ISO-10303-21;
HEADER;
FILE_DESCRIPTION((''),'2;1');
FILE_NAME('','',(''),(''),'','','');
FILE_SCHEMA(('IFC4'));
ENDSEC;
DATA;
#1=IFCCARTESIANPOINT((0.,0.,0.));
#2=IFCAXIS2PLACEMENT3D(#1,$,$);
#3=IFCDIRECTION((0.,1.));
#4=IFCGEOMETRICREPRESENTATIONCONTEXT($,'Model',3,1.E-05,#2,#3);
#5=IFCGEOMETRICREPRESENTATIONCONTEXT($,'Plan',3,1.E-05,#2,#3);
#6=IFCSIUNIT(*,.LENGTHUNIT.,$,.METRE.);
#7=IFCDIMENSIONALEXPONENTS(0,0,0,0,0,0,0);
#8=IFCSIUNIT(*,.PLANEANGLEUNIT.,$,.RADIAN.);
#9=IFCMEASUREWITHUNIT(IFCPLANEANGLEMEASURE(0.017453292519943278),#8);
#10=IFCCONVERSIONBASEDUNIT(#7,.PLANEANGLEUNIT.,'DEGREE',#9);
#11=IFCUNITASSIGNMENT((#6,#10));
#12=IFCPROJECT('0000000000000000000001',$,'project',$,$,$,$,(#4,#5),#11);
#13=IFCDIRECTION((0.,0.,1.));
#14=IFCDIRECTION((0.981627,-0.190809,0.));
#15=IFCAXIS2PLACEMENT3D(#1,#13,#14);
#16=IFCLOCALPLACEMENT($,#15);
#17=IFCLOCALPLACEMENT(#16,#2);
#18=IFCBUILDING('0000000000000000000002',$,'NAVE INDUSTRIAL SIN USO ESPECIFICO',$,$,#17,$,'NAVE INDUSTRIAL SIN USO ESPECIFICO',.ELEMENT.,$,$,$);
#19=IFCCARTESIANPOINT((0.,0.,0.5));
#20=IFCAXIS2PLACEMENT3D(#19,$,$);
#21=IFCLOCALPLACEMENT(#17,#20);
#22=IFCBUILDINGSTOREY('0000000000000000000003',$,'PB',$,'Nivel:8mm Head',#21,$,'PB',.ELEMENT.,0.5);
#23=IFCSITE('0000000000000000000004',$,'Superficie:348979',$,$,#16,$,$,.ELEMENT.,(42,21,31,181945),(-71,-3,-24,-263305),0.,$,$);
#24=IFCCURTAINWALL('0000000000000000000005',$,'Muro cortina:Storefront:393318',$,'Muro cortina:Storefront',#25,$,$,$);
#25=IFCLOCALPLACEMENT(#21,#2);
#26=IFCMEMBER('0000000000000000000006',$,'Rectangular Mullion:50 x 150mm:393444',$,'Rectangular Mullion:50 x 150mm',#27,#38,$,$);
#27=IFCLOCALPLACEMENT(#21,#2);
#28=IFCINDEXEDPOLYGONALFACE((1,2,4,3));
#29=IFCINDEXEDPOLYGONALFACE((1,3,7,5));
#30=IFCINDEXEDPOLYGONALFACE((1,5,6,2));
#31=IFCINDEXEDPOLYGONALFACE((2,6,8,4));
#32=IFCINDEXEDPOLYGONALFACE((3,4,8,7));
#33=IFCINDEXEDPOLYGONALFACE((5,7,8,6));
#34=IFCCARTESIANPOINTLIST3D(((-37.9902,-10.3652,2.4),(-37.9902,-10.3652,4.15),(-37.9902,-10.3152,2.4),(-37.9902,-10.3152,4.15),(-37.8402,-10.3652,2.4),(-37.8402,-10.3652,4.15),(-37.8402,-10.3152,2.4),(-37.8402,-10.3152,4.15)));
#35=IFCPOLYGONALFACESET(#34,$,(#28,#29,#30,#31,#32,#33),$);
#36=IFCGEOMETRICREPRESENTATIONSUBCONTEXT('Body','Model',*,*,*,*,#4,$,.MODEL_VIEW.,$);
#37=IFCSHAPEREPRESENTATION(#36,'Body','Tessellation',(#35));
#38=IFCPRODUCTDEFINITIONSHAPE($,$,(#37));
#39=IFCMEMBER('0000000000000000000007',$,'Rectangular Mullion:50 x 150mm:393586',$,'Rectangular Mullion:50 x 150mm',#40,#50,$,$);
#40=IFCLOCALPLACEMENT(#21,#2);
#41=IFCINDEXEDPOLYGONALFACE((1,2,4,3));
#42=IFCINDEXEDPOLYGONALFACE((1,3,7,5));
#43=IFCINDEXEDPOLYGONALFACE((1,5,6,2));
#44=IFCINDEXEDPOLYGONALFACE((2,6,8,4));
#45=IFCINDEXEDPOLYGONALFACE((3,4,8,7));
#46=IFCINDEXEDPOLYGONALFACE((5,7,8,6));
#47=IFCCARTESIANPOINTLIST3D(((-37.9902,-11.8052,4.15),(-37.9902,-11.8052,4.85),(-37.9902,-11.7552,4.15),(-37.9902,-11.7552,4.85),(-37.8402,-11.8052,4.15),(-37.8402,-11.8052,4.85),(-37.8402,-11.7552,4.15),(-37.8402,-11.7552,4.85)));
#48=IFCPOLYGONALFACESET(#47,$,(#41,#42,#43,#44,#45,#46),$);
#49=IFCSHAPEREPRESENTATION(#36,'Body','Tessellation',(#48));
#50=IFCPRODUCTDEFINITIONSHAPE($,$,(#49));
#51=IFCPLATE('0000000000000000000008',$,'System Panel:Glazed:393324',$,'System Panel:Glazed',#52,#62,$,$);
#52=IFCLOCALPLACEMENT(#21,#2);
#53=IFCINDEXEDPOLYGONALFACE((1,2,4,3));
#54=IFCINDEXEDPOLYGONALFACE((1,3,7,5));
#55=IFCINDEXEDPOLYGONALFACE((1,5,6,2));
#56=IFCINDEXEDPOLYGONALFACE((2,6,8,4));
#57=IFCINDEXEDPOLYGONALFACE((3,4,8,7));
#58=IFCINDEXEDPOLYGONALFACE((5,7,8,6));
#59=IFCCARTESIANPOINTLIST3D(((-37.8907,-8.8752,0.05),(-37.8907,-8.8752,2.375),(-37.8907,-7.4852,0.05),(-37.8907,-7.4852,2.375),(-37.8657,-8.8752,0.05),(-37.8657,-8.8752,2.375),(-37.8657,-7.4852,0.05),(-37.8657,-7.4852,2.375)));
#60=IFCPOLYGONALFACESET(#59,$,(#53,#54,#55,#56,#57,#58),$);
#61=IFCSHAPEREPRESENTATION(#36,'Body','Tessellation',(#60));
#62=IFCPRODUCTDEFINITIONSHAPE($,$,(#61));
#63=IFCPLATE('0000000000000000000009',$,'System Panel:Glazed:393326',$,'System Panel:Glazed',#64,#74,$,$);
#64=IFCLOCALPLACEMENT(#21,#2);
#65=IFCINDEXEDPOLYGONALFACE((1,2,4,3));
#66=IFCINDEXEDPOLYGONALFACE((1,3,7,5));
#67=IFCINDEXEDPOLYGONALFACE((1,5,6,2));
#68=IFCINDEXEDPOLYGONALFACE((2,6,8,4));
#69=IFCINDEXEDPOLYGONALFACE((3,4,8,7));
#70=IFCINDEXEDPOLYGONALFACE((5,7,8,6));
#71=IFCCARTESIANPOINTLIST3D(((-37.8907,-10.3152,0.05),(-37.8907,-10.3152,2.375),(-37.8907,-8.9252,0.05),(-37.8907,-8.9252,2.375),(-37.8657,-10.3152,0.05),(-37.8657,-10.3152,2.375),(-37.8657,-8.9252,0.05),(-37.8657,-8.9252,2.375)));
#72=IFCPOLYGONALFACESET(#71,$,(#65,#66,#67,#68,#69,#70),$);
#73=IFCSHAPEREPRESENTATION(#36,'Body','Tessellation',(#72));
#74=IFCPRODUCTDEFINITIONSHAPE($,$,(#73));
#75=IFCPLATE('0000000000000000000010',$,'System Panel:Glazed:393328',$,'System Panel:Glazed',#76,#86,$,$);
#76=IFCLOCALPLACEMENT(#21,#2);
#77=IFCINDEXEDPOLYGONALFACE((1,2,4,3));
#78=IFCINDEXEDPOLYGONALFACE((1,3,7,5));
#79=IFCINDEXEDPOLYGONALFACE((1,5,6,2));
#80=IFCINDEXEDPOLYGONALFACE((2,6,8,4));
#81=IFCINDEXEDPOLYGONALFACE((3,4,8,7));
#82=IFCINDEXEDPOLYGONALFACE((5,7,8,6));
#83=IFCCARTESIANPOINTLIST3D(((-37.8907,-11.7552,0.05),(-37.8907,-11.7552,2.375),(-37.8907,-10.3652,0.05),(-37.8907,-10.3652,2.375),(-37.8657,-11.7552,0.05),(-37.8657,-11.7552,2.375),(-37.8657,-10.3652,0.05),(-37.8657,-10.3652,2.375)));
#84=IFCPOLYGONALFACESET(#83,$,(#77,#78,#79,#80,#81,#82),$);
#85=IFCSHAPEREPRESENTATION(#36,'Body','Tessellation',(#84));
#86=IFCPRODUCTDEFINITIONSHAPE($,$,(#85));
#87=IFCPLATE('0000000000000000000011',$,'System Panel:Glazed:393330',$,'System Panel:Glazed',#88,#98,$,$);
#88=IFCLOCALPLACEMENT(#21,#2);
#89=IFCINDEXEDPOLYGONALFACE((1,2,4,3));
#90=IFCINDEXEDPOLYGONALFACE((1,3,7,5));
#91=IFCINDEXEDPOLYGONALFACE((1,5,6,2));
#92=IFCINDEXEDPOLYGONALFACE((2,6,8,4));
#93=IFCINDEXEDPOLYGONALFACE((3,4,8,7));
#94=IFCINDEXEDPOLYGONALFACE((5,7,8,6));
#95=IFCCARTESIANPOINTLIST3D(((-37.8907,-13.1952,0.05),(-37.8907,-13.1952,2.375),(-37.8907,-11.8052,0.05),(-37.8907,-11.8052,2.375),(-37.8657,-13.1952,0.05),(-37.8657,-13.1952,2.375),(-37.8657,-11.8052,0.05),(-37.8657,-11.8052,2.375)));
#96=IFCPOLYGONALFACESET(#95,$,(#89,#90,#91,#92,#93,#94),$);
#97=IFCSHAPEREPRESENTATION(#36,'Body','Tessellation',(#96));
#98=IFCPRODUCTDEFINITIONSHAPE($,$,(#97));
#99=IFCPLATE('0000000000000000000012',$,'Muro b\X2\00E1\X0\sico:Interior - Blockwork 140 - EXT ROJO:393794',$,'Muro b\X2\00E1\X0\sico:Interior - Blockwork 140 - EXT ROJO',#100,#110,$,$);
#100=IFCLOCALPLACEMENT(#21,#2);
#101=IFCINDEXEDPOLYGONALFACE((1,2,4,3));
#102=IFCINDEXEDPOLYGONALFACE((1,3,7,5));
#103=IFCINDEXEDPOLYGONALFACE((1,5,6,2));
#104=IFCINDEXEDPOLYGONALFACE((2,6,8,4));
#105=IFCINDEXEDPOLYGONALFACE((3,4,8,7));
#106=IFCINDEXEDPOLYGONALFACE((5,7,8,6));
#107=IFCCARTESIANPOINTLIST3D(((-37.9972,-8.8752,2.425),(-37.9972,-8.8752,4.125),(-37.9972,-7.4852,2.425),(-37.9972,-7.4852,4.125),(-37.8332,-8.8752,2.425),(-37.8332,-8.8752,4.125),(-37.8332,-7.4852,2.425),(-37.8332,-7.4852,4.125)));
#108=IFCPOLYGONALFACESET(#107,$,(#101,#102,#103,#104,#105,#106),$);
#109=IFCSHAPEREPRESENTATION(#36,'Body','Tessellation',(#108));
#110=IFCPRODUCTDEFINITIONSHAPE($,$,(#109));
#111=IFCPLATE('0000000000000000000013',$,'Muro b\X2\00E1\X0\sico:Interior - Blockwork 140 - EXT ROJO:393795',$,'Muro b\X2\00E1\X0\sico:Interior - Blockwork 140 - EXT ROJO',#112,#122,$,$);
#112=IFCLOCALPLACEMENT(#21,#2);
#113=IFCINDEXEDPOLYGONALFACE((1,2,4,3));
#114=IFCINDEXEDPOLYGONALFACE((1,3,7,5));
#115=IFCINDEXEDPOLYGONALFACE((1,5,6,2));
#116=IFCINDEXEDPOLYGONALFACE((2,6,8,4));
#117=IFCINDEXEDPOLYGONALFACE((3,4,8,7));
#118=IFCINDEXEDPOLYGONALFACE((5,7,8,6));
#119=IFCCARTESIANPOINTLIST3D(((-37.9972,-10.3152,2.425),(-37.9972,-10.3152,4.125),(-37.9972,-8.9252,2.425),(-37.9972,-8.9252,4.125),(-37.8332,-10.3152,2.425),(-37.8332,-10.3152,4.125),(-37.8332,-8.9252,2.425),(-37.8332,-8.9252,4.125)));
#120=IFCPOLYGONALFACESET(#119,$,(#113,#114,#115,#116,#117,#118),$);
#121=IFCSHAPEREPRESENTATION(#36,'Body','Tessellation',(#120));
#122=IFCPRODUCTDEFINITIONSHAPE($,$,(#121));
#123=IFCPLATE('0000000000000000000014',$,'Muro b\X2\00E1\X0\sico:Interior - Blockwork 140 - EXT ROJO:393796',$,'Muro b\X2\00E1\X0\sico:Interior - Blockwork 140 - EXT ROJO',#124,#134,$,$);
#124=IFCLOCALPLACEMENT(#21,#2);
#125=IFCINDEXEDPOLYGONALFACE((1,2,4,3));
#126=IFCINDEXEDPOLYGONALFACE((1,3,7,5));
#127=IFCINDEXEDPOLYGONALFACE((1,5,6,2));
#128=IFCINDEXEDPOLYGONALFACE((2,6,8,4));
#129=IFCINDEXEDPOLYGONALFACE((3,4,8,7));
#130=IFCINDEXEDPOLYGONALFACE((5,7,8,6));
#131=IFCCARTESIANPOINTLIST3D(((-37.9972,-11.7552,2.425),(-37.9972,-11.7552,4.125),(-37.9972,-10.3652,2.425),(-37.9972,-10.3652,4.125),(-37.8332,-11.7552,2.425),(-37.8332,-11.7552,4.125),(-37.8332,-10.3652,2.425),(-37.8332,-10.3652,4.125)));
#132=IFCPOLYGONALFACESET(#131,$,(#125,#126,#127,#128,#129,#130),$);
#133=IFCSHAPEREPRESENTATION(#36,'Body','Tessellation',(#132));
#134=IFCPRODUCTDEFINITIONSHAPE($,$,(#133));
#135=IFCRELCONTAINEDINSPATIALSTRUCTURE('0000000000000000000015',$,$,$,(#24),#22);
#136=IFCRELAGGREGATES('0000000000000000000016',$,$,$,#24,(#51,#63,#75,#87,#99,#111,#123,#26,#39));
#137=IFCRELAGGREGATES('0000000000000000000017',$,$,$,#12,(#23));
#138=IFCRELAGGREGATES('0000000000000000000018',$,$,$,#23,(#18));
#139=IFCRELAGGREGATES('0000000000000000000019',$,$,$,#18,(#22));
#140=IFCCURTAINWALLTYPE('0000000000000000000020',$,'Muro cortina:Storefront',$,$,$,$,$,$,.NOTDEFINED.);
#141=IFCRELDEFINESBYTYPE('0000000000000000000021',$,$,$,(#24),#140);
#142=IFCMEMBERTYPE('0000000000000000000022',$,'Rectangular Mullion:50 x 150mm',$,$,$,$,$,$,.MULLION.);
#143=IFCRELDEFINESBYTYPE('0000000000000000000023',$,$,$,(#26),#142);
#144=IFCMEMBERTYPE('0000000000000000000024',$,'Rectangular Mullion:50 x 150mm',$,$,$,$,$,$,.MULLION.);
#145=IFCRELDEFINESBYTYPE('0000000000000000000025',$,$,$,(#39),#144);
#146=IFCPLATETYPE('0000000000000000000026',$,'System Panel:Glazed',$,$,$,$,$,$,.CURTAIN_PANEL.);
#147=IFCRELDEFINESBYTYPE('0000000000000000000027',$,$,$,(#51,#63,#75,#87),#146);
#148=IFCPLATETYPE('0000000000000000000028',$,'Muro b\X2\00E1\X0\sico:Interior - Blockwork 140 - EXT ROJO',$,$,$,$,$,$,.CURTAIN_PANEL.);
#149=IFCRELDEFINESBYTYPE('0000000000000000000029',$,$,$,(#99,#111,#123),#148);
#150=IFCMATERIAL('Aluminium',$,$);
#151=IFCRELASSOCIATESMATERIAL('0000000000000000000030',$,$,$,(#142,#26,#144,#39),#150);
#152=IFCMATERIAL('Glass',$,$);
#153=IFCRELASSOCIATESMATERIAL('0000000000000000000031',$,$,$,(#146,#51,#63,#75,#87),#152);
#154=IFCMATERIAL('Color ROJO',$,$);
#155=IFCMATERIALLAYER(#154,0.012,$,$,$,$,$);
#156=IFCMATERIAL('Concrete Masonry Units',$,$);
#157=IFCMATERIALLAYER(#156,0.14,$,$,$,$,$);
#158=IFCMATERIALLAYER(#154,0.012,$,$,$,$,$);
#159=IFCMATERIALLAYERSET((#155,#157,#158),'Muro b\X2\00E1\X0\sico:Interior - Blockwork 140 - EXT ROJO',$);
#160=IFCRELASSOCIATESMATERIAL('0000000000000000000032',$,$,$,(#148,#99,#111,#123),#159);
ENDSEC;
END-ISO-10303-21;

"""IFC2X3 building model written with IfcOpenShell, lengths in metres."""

from ifc_helpers import new_model, entity, si_unit, converted_unit, direction, frame, frame_2d, origin, origin_2d_with_axis, place, context, subcontext, project, spatial, rectangle, extrude, source, transform, mapped, material, layer, layer_set, layer_usage, type_object, type_shapes, element, aggregate, save


model = new_model("IFC2X3")

# Units and contexts
model_context = context("Model", 3, precision=1e-05, world=origin(), true_north=direction((0.0, 1.0)))
plan_context = context("Plan", 3, precision=1e-05, world=origin(), true_north=direction((0.0, 1.0)))
body_context = subcontext(model_context, "Body", "Model", "MODEL_VIEW")
ifc_project = project(units=[si_unit("LENGTHUNIT", "METRE"), converted_unit("PLANEANGLEUNIT", "DEGREE", entity("IfcPlaneAngleMeasure", 0.017453292519943278), si_unit("PLANEANGLEUNIT", "RADIAN"), dimensions=[0, 0, 0, 0, 0, 0, 0])], contexts=[model_context, plan_context])

# Site, building, storey
site_placement = place(None, frame((0.0, 0.0, 0.0), z_axis=(0.0, 0.0, 1.0), x_axis=(0.981627, -0.190809, 0.0)))
site = spatial("IfcSite", under=ifc_project, at=site_placement, Name="Superficie:348979", CompositionType="ELEMENT", RefLatitude=(42, 21, 31, 181945), RefLongitude=(-71, -3, -24, -263305), RefElevation=0.0)
building_placement = place(site_placement, origin())
building = spatial("IfcBuilding", under=site, at=building_placement, Name="NAVE INDUSTRIAL SIN USO ESPECIFICO", LongName="NAVE INDUSTRIAL SIN USO ESPECIFICO", CompositionType="ELEMENT")
storey_placement = place(building_placement, frame((0.0, 0.0, 0.5)))
storey = spatial("IfcBuildingStorey", under=building, at=storey_placement, Name="PB", ObjectType="Nivel:8mm Head", LongName="PB", CompositionType="ELEMENT", Elevation=0.5)

# Curtain wall, members, plates
curtain_wall_type = type_object("IfcCurtainWallType", Name="Muro cortina:Storefront", PredefinedType="NOTDEFINED")
curtain_wall_placement = place(storey_placement, frame((0.0, 0.0, -0.5)))
curtain_wall = element("IfcCurtainWall", 1, at=curtain_wall_placement, inside=storey, type_object=curtain_wall_type, Name="Muro cortina:Storefront:393318", ObjectType="Muro cortina:Storefront")
ifc_material_1 = material(Name="Aluminium")
member_type_1 = type_object("IfcMemberType", Name="Rectangular Mullion:50 x 150mm", PredefinedType="MULLION", material=ifc_material_1)
shared_shape_1 = source(origin(), body_context, "Body", "SweptSolid", [
    extrude(rectangle(XDim=0.05, YDim=0.15, at=origin_2d_with_axis()), frame((0.0, 0.0, -1.75), z_axis=(0.0, 0.0, 1.0), x_axis=(-1.0, 0.0, 0.0)), (0.0, 0.0, 1.0), 1.75),
])
type_shapes(member_type_1, [shared_shape_1])
member_1_placement = place(curtain_wall_placement, frame((-37.9152, -10.3402, 2.9), z_axis=(0.0, 0.0, -1.0), x_axis=(0.0, -1.0, 0.0)))
member_1 = element("IfcMember", 2, at=member_1_placement, type_object=member_type_1, material=ifc_material_1, Name="Rectangular Mullion:50 x 150mm:393444", ObjectType="Rectangular Mullion:50 x 150mm", context=body_context, shape_type="MappedRepresentation", body=[
    mapped(shared_shape_1, transform((0.0, 0.0, 0.0), scale=1.0)),
])
member_type_2 = type_object("IfcMemberType", Name="Rectangular Mullion:50 x 150mm", PredefinedType="MULLION", material=ifc_material_1)
shared_shape_2 = source(origin(), body_context, "Body", "SweptSolid", [
    extrude(rectangle(XDim=0.05, YDim=0.15, at=origin_2d_with_axis()), frame((0.0, 0.0, -0.7), z_axis=(0.0, 0.0, 1.0), x_axis=(-1.0, 0.0, 0.0)), (0.0, 0.0, 1.0), 0.7),
])
type_shapes(member_type_2, [shared_shape_2])
member_2_placement = place(curtain_wall_placement, frame((-37.9152, -11.7802, 4.65), z_axis=(0.0, 0.0, -1.0), x_axis=(0.0, -1.0, 0.0)))
member_2 = element("IfcMember", 3, at=member_2_placement, type_object=member_type_2, material=ifc_material_1, Name="Rectangular Mullion:50 x 150mm:393586", ObjectType="Rectangular Mullion:50 x 150mm", context=body_context, shape_type="MappedRepresentation", body=[
    mapped(shared_shape_2, transform((0.0, 0.0, 0.0), scale=1.0)),
])
ifc_material_2 = material(Name="Glass")
plate_type_1 = type_object("IfcPlateType", Name="System Panel:Glazed", PredefinedType="CURTAIN_PANEL", material=ifc_material_2)
shared_shape_3 = source(origin(), body_context, "Body", "SweptSolid", [
    extrude(rectangle(XDim=0.025, YDim=1.39, at=origin_2d_with_axis()), frame((0.695, 0.0125, 0.0), z_axis=(0.0, 0.0, 1.0), x_axis=(0.0, 1.0, 0.0)), (0.0, 0.0, 1.0), 2.325),
])
type_shapes(plate_type_1, [shared_shape_3])
plate_1_placement = place(curtain_wall_placement, frame((-37.8907, -7.4852, 0.55), z_axis=(0.0, 0.0, 1.0), x_axis=(0.0, -1.0, 0.0)))
plate_1 = element("IfcPlate", 4, at=plate_1_placement, type_object=plate_type_1, material=ifc_material_2, Name="System Panel:Glazed:393324", ObjectType="System Panel:Glazed", context=body_context, shape_type="MappedRepresentation", body=[
    mapped(shared_shape_3, transform((0.0, 0.0, 0.0), scale=1.0)),
])
plate_2_placement = place(curtain_wall_placement, frame((-37.8907, -8.9252, 0.55), z_axis=(0.0, 0.0, 1.0), x_axis=(0.0, -1.0, 0.0)))
plate_2 = element("IfcPlate", 5, at=plate_2_placement, type_object=plate_type_1, material=ifc_material_2, Name="System Panel:Glazed:393326", ObjectType="System Panel:Glazed", context=body_context, shape_type="MappedRepresentation", body=[
    mapped(shared_shape_3, transform((0.0, 0.0, 0.0), scale=1.0)),
])
plate_3_placement = place(curtain_wall_placement, frame((-37.8907, -10.3652, 0.55), z_axis=(0.0, 0.0, 1.0), x_axis=(0.0, -1.0, 0.0)))
plate_3 = element("IfcPlate", 6, at=plate_3_placement, type_object=plate_type_1, material=ifc_material_2, Name="System Panel:Glazed:393328", ObjectType="System Panel:Glazed", context=body_context, shape_type="MappedRepresentation", body=[
    mapped(shared_shape_3, transform((0.0, 0.0, 0.0), scale=1.0)),
])
plate_4_placement = place(curtain_wall_placement, frame((-37.8907, -11.8052, 0.55), z_axis=(0.0, 0.0, 1.0), x_axis=(0.0, -1.0, 0.0)))
plate_4 = element("IfcPlate", 7, at=plate_4_placement, type_object=plate_type_1, material=ifc_material_2, Name="System Panel:Glazed:393330", ObjectType="System Panel:Glazed", context=body_context, shape_type="MappedRepresentation", body=[
    mapped(shared_shape_3, transform((0.0, 0.0, 0.0), scale=1.0)),
])
ifc_material_3 = material(Name="Color ROJO")
ifc_layer_1 = layer(ifc_material_3, 0.012)
ifc_material_4 = material(Name="Concrete Masonry Units")
ifc_layer_2 = layer(ifc_material_4, 0.14)
ifc_layer_3 = layer(ifc_material_3, 0.012)
ifc_layer_set = layer_set([ifc_layer_1, ifc_layer_2, ifc_layer_3], Name="Muro básico:Interior - Blockwork 140 - EXT ROJO")
ifc_layer_usage_1 = layer_usage(ifc_layer_set, "AXIS2", "NEGATIVE", 0.082)
plate_type_2 = type_object("IfcPlateType", Name="Muro básico:Interior - Blockwork 140 - EXT ROJO", PredefinedType="CURTAIN_PANEL", material=ifc_layer_set)
plate_5_placement = place(storey_placement, frame((-37.9152, -7.4852, 2.425), z_axis=(0.0, 0.0, 1.0), x_axis=(0.0, -1.0, 0.0)))
plate_5 = element("IfcPlate", 8, at=plate_5_placement, type_object=plate_type_2, material=ifc_layer_usage_1, Name="Muro básico:Interior - Blockwork 140 - EXT ROJO:393794", ObjectType="Muro básico:Interior - Blockwork 140 - EXT ROJO", context=body_context, shape_type="SweptSolid", body=[
    extrude(rectangle(XDim=0.164, YDim=1.39, at=frame_2d((0.0, 0.0), x_axis=(1.0, 0.0))), frame((0.695, 0.0, 0.0), z_axis=(0.0, 0.0, 1.0), x_axis=(0.0, 1.0, 0.0)), (0.0, 0.0, 1.0), 1.7),
])
ifc_layer_usage_2 = layer_usage(ifc_layer_set, "AXIS2", "POSITIVE", -0.082)
plate_6_placement = place(storey_placement, frame((-37.9152, -8.9252, 2.425), z_axis=(0.0, 0.0, 1.0), x_axis=(0.0, -1.0, 0.0)))
plate_6 = element("IfcPlate", 9, at=plate_6_placement, type_object=plate_type_2, material=ifc_layer_usage_2, Name="Muro básico:Interior - Blockwork 140 - EXT ROJO:393795", ObjectType="Muro básico:Interior - Blockwork 140 - EXT ROJO", context=body_context, shape_type="SweptSolid", body=[
    extrude(rectangle(XDim=0.164, YDim=1.39, at=frame_2d((0.0, 0.0), x_axis=(1.0, 0.0))), frame((0.695, 0.0, 0.0), z_axis=(0.0, 0.0, 1.0), x_axis=(0.0, 1.0, 0.0)), (0.0, 0.0, 1.0), 1.7),
])
ifc_layer_usage_3 = layer_usage(ifc_layer_set, "AXIS2", "NEGATIVE", 0.082)
plate_7_placement = place(storey_placement, frame((-37.9152, -10.3652, 2.425), z_axis=(0.0, 0.0, 1.0), x_axis=(0.0, -1.0, 0.0)))
plate_7 = element("IfcPlate", 10, at=plate_7_placement, type_object=plate_type_2, material=ifc_layer_usage_3, Name="Muro básico:Interior - Blockwork 140 - EXT ROJO:393796", ObjectType="Muro básico:Interior - Blockwork 140 - EXT ROJO", context=body_context, shape_type="SweptSolid", body=[
    extrude(rectangle(XDim=0.164, YDim=1.39, at=frame_2d((0.0, 0.0), x_axis=(1.0, 0.0))), frame((0.695, 0.0, 0.0), z_axis=(0.0, 0.0, 1.0), x_axis=(0.0, 1.0, 0.0)), (0.0, 0.0, 1.0), 1.7),
])
aggregate(curtain_wall, [plate_1, plate_2, plate_3, plate_4, plate_5, plate_6, plate_7, member_1, member_2])

save(model, "model.ifc")
